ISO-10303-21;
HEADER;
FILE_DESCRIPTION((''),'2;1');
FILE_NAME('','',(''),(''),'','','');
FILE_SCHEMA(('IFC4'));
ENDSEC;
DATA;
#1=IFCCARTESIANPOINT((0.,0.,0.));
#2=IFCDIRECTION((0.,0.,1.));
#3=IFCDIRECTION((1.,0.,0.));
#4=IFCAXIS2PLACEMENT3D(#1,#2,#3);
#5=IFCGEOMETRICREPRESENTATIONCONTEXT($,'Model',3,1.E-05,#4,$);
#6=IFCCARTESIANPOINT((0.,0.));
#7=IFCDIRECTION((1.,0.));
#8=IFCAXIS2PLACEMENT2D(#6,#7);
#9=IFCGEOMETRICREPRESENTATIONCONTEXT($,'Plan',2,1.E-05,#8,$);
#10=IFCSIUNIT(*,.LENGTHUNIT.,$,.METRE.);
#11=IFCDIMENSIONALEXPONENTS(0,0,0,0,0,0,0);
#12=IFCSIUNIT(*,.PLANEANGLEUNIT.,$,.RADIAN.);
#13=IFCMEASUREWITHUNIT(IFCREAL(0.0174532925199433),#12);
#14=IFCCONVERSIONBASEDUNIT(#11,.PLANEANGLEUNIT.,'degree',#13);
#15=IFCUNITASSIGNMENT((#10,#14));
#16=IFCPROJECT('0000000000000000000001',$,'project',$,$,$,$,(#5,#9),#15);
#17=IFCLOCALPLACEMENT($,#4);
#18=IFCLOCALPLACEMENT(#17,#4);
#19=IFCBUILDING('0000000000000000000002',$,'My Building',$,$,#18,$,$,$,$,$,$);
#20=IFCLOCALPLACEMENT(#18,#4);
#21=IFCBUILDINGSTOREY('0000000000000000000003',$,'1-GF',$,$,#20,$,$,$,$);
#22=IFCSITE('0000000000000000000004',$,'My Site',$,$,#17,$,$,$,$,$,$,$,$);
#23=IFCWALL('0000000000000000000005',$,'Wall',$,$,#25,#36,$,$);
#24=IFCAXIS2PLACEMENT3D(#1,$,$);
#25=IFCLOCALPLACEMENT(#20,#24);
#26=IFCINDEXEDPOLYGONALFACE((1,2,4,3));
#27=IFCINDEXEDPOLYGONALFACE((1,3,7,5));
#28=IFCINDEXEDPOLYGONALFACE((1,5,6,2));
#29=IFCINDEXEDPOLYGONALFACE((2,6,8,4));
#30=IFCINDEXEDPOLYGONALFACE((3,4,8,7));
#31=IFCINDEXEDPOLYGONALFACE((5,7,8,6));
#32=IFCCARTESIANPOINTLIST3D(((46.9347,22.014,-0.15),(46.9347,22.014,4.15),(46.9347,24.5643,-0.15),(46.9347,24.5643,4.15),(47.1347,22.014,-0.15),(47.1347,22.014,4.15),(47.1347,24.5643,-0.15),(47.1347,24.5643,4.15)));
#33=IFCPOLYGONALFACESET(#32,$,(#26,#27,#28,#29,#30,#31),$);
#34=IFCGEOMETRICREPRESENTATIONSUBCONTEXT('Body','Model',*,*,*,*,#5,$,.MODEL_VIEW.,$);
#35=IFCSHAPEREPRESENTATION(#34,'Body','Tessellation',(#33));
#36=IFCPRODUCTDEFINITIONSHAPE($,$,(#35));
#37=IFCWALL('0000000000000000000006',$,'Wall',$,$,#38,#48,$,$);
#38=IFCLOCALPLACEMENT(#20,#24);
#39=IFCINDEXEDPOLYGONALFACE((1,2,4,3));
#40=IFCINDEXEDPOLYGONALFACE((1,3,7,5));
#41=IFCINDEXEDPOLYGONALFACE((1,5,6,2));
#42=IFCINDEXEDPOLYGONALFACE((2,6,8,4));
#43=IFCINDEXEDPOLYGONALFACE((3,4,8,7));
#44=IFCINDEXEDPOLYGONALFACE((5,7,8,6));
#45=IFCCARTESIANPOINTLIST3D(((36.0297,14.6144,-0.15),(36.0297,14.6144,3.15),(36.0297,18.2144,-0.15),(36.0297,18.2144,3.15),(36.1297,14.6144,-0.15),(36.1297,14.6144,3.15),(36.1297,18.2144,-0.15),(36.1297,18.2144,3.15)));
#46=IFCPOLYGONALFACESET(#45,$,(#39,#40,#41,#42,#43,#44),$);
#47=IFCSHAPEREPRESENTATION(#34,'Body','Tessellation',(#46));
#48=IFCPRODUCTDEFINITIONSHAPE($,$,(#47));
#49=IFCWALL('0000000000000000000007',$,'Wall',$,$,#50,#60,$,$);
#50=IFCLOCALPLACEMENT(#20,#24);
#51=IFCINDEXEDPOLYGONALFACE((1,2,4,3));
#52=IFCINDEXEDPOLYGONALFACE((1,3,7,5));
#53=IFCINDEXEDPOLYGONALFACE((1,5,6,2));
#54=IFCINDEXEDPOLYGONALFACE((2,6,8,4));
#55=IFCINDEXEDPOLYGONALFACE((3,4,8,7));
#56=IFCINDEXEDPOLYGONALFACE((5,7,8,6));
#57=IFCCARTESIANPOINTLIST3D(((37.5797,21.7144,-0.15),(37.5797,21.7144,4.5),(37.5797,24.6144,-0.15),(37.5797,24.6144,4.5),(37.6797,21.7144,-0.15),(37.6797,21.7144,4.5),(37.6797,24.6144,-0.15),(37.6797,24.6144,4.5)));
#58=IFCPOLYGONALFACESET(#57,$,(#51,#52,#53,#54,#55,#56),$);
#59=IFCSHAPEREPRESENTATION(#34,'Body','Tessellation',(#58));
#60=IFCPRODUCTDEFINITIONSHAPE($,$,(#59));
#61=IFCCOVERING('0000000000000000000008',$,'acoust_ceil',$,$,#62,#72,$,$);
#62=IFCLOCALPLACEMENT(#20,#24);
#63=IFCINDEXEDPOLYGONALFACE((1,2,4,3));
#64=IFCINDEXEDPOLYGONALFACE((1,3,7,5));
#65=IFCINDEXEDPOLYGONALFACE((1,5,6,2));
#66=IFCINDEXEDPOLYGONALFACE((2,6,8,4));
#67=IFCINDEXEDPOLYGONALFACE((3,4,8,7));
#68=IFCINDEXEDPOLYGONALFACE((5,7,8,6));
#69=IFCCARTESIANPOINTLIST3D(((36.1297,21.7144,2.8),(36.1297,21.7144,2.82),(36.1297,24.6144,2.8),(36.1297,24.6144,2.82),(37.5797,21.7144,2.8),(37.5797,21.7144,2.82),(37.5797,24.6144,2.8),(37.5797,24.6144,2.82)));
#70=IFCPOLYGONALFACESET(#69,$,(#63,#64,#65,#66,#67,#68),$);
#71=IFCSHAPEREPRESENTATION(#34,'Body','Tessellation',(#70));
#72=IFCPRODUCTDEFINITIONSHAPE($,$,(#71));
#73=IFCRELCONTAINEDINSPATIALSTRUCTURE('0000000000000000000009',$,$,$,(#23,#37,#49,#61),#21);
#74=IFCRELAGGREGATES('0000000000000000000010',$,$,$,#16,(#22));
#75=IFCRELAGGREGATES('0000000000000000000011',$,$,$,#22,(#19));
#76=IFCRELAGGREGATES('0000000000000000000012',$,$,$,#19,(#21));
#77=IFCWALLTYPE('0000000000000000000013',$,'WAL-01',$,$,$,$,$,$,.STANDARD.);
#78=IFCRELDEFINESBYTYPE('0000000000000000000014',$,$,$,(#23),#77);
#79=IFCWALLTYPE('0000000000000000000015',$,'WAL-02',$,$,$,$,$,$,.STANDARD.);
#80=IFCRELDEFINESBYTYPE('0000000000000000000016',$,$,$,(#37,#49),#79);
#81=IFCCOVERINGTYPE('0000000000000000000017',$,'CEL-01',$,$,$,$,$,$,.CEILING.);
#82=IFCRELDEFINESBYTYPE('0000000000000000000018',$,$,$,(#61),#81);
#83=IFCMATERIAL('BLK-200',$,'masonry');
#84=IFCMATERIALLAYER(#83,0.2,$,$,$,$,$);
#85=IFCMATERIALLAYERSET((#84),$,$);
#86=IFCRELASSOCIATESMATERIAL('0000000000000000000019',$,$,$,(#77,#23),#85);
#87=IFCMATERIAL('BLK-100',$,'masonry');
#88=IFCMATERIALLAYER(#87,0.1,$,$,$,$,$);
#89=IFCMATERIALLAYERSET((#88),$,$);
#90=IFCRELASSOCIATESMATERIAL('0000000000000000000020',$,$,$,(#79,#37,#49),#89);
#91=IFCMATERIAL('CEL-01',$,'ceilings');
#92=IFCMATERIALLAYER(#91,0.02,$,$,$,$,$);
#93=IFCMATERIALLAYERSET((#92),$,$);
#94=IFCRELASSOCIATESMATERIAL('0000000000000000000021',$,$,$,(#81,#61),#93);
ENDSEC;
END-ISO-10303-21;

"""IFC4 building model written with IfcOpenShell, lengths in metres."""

from ifc_helpers import new_model, entity, si_unit, converted_unit, frame, origin_with_axes, origin_2d_with_axis, place, context, subcontext, project, spatial, line, indexed_curve, outline, extrude, material, layer, layer_set, layer_usage, type_object, element, save


model = new_model("IFC4")

# Units and contexts
model_context = context("Model", 3, precision=1e-05, world=origin_with_axes())
plan_context = context("Plan", 2, precision=1e-05, world=origin_2d_with_axis())
body_context_1 = subcontext(model_context, "Body", "Model", "MODEL_VIEW")
ifc_project = project(units=[si_unit("LENGTHUNIT", "METRE"), converted_unit("PLANEANGLEUNIT", "degree", entity("IfcReal", 0.0174532925199433), si_unit("PLANEANGLEUNIT", "RADIAN"), dimensions=[0, 0, 0, 0, 0, 0, 0])], contexts=[model_context, plan_context])

# Site, building, storey
site_placement = place(None, origin_with_axes())
site = spatial("IfcSite", under=ifc_project, at=site_placement, Name="My Site")
building_placement = place(site_placement, origin_with_axes())
building = spatial("IfcBuilding", under=site, at=building_placement, Name="My Building")
storey_placement = place(building_placement, origin_with_axes())
storey = spatial("IfcBuildingStorey", under=building, at=storey_placement, Name="1-GF")

# Shared definitions
ifc_material_1 = material(Name="BLK-200", Category="masonry")
ifc_layer_1 = layer(ifc_material_1, 0.2)
ifc_layer_set_1 = layer_set([ifc_layer_1])
wall_type_1 = type_object("IfcWallType", Name="WAL-01", PredefinedType="STANDARD", material=ifc_layer_set_1)

# Walls
ifc_layer_usage_1 = layer_usage(ifc_layer_set_1, "AXIS2", "POSITIVE", 0.0)
wall_1_placement = place(storey_placement, frame((47.1347, 22.014, -0.15), z_axis=(0.0, 0.0, 1.0), x_axis=(0.0, 1.0, 0.0)))
element("IfcWall", 1, at=wall_1_placement, inside=storey, type_object=wall_type_1, material=ifc_layer_usage_1, Name="Wall", context=body_context_1, shape_type="SweptSolid", body=[
    extrude(outline(indexed_curve([(0.0, 0.0), (0.0, 0.2), (2.5502, 0.2), (2.5502, 0.0), (0.0, 0.0)], self_intersect=False)), origin_with_axes(), (0.0, 0.0, 1.0), 4.3),
])
ifc_material_2 = material(Name="BLK-100", Category="masonry")
ifc_layer_2 = layer(ifc_material_2, 0.1)
ifc_layer_set_2 = layer_set([ifc_layer_2])
ifc_layer_usage_2 = layer_usage(ifc_layer_set_2, "AXIS2", "POSITIVE", 0.0)
wall_type_2 = type_object("IfcWallType", Name="WAL-02", PredefinedType="STANDARD", material=ifc_layer_set_2)
wall_2_placement = place(storey_placement, frame((36.1297, 14.6144, -0.15), z_axis=(0.0, 0.0, 1.0), x_axis=(0.0, 1.0, 0.0)))
element("IfcWall", 2, at=wall_2_placement, inside=storey, type_object=wall_type_2, material=ifc_layer_usage_2, Name="Wall", context=body_context_1, shape_type="SweptSolid", body=[
    extrude(outline(indexed_curve([(0.0, 0.0), (0.0, 0.1), (3.6, 0.1), (3.6, 0.0), (0.0, 0.0)], self_intersect=False)), origin_with_axes(), (0.0, 0.0, 1.0), 3.3),
])
ifc_layer_usage_3 = layer_usage(ifc_layer_set_2, "AXIS2", "POSITIVE", 0.0)
wall_3_placement = place(storey_placement, frame((37.6797, 21.7144, -0.15), z_axis=(0.0, 0.0, 1.0), x_axis=(0.0, 1.0, 0.0)))
element("IfcWall", 3, at=wall_3_placement, inside=storey, type_object=wall_type_2, material=ifc_layer_usage_3, Name="Wall", context=body_context_1, shape_type="SweptSolid", body=[
    extrude(outline(indexed_curve([(0.0, 0.0), (0.0, 0.1), (2.9, 0.1), (2.9, 0.0), (0.0, 0.0)], self_intersect=False)), origin_with_axes(), (0.0, 0.0, 1.0), 4.65),
])

# Covering
ifc_material_3 = material(Name="CEL-01", Category="ceilings")
ifc_layer_3 = layer(ifc_material_3, 0.02)
ifc_layer_set_3 = layer_set([ifc_layer_3])
ifc_layer_usage_4 = layer_usage(ifc_layer_set_3, "AXIS3", "POSITIVE", 0.0)
covering_type_1 = type_object("IfcCoveringType", Name="CEL-01", PredefinedType="CEILING", material=ifc_layer_set_3)
covering_1_placement = place(storey_placement, frame((36.1297, 21.7144, 2.8), z_axis=(0.0, 0.0, 1.0), x_axis=(1.0, 0.0, 0.0)))
element("IfcCovering", 4, at=covering_1_placement, inside=storey, type_object=covering_type_1, material=ifc_layer_usage_4, Name="acoust_ceil", context=body_context_1, shape_type="SweptSolid", body=[
    extrude(outline(indexed_curve([(0.0, 0.0), (1.45, 0.0), (1.45, 2.9), (0.0, 2.9)], segments=[line(3, 2), line(2, 1), line(1, 4), line(4, 3)], self_intersect=False)), None, (0.0, 0.0, 1.0), 0.02),
])

save(model, "model.ifc")
